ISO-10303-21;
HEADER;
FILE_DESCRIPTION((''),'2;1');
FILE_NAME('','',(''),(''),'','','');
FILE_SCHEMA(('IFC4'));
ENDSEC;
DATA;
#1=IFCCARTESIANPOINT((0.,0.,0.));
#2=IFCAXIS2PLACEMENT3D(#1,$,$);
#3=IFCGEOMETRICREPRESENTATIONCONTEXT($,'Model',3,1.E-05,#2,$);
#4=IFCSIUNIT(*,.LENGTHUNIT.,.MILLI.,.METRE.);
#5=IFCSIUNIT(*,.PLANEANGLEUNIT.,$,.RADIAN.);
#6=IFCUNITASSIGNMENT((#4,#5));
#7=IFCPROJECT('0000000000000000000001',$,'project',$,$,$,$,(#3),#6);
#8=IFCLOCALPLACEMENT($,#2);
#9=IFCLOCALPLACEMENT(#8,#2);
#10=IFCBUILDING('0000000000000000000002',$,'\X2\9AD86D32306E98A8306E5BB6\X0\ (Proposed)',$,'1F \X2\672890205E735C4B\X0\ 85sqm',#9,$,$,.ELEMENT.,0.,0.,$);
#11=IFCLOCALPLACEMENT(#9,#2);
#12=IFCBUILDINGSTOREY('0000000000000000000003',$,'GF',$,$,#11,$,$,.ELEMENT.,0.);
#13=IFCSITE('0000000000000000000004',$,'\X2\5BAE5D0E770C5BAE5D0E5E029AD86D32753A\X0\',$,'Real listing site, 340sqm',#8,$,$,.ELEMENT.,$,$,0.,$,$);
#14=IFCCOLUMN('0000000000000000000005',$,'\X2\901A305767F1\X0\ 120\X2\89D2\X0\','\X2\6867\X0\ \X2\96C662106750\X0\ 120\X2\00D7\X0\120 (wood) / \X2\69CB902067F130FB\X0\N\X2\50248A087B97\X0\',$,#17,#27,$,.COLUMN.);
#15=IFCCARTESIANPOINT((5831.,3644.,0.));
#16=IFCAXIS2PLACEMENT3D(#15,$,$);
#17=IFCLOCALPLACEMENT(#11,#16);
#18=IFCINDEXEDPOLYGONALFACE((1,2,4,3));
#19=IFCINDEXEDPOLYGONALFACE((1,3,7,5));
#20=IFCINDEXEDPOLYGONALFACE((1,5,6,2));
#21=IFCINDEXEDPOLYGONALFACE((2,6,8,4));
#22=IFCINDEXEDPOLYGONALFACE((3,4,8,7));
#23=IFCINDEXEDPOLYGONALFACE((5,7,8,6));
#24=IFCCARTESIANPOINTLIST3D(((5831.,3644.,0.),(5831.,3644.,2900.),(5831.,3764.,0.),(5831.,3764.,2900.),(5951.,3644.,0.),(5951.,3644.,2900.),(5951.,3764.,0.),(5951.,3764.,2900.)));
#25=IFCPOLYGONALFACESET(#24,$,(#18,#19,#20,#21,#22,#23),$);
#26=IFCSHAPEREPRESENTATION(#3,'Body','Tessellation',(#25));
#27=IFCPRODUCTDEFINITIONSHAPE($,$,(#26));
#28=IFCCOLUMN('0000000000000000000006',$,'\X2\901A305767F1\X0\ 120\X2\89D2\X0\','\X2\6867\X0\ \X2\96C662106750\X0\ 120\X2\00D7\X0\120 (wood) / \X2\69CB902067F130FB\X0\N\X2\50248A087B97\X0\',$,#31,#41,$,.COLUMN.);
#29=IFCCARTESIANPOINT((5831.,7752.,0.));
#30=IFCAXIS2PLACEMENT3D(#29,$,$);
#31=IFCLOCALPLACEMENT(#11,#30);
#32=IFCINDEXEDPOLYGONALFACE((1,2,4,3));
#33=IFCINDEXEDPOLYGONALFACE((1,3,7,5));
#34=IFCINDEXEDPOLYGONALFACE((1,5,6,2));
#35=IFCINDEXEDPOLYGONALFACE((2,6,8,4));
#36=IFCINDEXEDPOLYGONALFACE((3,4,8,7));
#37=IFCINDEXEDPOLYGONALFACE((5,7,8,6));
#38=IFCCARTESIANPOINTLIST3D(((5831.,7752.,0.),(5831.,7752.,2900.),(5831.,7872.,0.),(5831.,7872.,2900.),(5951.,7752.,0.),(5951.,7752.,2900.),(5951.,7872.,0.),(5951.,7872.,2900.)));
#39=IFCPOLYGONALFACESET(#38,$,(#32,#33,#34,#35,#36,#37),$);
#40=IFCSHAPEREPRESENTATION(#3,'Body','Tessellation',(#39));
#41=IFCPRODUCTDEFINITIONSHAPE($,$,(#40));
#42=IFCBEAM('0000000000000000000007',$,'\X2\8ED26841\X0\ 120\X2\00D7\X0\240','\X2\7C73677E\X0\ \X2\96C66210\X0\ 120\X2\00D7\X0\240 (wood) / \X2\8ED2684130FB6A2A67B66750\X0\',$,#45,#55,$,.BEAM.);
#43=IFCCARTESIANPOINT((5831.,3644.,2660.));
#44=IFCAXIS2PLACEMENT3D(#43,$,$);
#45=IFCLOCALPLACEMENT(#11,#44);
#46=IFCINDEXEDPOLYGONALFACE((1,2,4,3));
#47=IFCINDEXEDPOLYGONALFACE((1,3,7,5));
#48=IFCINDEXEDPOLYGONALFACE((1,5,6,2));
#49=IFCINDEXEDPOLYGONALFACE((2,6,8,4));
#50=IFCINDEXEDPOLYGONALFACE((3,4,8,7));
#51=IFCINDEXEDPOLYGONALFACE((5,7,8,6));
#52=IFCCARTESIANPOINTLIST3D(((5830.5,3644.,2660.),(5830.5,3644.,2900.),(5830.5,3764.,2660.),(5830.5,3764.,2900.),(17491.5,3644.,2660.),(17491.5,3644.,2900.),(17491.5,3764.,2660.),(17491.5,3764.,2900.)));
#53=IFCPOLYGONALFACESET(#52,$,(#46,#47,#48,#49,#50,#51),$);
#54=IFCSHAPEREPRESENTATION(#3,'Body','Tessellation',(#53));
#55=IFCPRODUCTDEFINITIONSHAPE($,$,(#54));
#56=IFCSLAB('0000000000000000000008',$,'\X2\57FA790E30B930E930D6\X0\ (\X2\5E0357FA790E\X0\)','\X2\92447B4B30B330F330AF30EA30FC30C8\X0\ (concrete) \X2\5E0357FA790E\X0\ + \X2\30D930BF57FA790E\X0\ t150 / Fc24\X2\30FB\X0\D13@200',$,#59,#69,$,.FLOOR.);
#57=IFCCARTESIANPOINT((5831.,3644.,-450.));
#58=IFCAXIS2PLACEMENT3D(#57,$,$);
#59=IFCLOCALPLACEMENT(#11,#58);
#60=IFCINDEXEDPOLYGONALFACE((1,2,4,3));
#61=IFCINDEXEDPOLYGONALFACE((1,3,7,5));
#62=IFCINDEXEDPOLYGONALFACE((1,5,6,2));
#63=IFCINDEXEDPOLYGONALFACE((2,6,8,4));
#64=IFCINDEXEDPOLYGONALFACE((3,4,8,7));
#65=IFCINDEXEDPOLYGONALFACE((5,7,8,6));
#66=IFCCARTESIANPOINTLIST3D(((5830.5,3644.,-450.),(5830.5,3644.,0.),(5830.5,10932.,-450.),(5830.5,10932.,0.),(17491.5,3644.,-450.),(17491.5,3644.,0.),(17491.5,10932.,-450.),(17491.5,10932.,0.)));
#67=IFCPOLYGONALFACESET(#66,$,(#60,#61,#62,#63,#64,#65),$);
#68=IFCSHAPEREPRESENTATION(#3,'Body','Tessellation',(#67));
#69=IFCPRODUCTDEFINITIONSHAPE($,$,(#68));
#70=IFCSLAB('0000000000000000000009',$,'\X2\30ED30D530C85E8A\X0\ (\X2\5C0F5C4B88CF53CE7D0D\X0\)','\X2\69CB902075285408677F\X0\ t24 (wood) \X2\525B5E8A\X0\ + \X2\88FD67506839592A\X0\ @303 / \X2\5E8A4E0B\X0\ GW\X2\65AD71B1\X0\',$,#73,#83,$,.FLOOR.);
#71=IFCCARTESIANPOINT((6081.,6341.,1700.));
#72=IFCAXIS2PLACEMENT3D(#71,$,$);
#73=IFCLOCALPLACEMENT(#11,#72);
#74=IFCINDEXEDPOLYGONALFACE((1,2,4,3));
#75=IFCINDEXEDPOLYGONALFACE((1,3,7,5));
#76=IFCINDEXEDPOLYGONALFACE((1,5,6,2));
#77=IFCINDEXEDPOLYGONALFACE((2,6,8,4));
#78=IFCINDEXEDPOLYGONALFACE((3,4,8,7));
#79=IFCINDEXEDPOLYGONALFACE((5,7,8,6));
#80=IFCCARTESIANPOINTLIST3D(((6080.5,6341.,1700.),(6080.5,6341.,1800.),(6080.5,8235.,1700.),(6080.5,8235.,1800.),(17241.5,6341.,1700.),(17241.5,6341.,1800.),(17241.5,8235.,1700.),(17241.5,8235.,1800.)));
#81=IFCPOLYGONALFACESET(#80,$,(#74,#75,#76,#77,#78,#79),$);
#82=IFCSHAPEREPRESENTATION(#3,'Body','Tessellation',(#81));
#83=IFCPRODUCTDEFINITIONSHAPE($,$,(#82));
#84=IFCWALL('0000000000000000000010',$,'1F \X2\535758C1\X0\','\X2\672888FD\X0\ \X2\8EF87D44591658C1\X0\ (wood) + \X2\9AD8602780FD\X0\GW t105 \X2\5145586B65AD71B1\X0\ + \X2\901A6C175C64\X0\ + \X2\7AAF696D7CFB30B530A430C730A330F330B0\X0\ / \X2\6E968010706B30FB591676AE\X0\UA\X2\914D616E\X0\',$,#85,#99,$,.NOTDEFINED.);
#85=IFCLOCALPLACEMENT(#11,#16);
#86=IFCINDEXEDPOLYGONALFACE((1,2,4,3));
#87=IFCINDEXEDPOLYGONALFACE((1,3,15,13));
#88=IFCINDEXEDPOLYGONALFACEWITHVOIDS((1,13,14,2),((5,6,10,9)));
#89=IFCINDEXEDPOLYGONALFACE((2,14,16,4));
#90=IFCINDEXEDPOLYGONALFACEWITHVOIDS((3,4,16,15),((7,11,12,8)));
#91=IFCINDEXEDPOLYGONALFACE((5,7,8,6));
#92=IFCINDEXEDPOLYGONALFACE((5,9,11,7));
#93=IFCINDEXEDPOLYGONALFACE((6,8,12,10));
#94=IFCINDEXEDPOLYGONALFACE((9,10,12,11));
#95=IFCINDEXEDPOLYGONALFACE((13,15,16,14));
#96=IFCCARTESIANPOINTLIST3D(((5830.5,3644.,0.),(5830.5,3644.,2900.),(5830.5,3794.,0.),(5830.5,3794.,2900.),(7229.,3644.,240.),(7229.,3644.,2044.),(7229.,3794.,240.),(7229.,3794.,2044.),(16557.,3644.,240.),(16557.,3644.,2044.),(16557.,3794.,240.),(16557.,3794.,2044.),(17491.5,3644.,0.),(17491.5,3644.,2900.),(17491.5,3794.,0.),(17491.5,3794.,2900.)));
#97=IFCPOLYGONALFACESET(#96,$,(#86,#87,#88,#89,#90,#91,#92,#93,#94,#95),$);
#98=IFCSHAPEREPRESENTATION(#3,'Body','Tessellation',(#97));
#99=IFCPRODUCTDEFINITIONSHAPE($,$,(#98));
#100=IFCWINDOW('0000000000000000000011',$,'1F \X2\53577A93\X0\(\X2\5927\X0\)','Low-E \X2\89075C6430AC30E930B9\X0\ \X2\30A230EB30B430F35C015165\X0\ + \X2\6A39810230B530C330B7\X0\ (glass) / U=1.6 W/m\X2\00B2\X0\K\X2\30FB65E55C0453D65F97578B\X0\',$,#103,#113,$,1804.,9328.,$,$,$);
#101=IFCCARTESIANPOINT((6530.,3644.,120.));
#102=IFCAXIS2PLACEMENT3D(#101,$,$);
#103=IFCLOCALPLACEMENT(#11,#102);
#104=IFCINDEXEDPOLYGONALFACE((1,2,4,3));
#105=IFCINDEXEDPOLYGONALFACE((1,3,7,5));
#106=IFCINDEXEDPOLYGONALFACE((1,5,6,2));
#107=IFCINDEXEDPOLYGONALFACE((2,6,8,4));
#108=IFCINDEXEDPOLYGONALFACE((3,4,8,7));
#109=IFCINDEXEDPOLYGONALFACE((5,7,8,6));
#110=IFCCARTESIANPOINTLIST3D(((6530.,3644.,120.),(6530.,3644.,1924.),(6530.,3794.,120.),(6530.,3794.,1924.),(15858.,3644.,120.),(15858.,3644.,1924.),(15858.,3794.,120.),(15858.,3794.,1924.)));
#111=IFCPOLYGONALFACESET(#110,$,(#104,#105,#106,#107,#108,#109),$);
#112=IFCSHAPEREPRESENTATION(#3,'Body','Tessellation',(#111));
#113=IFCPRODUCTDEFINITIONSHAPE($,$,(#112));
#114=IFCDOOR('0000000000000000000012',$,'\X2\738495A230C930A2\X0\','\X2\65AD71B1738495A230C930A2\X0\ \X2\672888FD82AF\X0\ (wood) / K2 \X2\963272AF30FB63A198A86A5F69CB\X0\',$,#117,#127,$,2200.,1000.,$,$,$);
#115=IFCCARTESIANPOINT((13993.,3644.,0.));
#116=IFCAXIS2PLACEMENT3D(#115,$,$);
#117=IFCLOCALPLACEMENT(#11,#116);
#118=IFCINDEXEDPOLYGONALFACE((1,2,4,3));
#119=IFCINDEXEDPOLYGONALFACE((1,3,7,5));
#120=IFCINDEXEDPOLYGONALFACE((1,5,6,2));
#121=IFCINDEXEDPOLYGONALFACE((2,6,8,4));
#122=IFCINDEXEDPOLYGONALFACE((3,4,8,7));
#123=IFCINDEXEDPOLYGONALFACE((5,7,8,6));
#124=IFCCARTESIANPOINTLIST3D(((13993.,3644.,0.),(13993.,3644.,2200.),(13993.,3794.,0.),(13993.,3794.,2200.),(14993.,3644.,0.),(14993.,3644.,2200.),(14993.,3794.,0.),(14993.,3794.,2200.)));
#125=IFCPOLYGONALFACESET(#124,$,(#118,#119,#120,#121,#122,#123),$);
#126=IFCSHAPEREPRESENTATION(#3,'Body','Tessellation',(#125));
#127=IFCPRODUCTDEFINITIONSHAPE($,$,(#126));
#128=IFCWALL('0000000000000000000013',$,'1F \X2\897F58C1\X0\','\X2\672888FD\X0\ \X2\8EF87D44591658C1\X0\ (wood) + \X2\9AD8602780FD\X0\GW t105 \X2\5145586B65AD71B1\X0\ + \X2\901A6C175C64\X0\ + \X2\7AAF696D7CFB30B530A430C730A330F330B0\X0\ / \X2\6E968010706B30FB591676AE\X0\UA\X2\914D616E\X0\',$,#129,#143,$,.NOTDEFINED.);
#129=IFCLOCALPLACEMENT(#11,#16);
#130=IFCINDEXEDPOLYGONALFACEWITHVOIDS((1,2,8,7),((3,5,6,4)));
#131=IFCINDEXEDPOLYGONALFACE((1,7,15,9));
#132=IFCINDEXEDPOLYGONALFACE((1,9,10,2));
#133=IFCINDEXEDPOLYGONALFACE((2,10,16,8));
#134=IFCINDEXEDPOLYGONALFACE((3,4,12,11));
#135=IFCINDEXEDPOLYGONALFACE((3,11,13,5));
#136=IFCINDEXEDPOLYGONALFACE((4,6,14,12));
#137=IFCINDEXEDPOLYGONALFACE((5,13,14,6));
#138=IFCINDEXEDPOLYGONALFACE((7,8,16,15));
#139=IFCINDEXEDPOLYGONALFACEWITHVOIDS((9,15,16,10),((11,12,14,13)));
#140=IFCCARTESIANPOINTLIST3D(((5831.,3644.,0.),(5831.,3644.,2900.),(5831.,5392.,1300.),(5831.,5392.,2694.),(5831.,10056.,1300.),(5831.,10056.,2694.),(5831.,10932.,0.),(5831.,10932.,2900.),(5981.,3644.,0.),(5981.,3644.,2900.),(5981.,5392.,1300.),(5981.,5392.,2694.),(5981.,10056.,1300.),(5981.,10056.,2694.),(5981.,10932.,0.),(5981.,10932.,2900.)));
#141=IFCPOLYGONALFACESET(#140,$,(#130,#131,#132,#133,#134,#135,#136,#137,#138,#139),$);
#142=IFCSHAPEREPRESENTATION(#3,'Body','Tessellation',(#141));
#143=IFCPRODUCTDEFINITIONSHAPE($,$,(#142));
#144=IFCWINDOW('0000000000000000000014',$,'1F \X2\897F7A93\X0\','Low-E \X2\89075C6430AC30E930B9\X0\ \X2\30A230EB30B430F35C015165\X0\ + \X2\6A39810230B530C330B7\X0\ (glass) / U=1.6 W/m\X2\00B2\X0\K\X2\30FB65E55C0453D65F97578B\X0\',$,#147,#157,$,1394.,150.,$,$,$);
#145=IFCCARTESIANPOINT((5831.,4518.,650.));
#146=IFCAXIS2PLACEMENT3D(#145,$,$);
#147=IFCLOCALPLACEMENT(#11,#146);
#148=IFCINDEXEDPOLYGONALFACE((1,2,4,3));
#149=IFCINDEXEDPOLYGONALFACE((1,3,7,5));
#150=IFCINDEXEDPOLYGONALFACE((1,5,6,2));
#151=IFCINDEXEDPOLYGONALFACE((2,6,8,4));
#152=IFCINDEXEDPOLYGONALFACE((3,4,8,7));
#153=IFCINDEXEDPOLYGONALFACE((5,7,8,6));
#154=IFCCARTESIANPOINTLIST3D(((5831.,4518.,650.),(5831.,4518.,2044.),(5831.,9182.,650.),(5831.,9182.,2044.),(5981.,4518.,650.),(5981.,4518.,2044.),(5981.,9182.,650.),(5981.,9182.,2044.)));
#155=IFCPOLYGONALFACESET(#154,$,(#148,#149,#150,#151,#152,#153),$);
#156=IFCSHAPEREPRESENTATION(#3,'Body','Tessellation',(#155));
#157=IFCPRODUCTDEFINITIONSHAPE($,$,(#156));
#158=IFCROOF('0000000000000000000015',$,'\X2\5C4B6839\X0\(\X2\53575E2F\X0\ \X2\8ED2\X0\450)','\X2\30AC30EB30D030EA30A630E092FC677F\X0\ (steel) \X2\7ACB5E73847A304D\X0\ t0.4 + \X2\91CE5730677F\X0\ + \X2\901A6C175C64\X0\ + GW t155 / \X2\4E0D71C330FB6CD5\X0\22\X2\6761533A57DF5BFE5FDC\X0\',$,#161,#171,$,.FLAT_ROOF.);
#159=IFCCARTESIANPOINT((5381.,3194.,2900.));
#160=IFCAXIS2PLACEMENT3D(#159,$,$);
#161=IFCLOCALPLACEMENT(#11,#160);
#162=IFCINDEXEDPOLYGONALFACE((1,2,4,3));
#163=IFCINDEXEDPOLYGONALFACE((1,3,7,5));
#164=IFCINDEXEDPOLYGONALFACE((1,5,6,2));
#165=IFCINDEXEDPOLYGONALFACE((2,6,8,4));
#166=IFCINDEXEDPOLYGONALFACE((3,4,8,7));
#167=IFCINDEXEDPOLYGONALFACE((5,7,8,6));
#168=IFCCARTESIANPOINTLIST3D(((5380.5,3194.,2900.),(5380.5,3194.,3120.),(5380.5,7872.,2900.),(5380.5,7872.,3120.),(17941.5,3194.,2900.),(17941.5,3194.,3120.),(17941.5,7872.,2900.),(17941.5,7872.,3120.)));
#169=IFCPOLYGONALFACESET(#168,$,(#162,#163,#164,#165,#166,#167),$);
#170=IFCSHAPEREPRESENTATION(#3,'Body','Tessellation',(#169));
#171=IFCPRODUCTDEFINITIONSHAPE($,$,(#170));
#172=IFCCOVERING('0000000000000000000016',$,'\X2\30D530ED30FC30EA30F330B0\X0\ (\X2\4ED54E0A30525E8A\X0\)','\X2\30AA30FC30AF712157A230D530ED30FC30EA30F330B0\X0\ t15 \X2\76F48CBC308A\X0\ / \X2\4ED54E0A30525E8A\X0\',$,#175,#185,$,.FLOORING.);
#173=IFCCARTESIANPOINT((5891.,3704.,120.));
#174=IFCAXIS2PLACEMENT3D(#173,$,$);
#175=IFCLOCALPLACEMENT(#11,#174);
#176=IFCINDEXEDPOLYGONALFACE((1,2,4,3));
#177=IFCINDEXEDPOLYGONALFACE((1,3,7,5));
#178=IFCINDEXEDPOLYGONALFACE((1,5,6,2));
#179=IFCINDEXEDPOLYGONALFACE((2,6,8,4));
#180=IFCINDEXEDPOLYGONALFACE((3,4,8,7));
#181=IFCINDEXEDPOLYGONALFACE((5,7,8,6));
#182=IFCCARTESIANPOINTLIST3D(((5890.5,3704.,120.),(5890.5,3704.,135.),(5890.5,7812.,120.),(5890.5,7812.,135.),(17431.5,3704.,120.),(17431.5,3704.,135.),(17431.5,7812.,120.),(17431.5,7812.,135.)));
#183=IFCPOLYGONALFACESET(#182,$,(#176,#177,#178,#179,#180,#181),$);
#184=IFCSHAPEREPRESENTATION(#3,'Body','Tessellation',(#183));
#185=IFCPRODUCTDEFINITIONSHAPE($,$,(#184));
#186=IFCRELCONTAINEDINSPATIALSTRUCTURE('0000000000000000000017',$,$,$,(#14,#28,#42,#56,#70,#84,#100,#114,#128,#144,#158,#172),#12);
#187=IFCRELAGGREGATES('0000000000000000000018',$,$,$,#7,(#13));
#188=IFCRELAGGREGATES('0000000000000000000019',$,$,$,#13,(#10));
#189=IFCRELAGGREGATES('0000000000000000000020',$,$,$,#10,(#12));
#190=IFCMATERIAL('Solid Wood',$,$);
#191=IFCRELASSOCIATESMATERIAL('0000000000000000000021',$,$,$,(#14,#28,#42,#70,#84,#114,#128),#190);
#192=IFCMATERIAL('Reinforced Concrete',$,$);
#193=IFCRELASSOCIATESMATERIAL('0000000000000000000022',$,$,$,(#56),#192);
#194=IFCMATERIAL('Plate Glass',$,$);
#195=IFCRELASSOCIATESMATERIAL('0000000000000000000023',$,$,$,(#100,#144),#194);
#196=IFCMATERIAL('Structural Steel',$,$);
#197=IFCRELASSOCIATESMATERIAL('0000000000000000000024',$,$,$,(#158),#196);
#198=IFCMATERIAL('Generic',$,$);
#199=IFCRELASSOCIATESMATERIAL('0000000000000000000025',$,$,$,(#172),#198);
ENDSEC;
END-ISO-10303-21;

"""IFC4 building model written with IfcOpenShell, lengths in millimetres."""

from ifc_helpers import new_model, si_unit, frame, frame_2d, origin, place, context, project, spatial, rectangle, extrude, material, element, fill, save


model = new_model("IFC4")

# Units and contexts
model_context = context("Model", 3, precision=1e-05, world=origin())
ifc_project = project(units=[si_unit("LENGTHUNIT", "METRE", prefix="MILLI"), si_unit("PLANEANGLEUNIT", "RADIAN")], contexts=[model_context])

# Site, building, storey
site_placement = place(None, origin())
site = spatial("IfcSite", under=ifc_project, at=site_placement, Name="宮崎県宮崎市高洲町", ObjectType="Real listing site, 340sqm", CompositionType="ELEMENT", RefElevation=0.0)
building_placement = place(site_placement, origin())
building = spatial("IfcBuilding", under=site, at=building_placement, Name="高洲の風の家 (Proposed)", ObjectType="1F 木造平屋 85sqm", CompositionType="ELEMENT", ElevationOfRefHeight=0.0, ElevationOfTerrain=0.0)
storey_placement = place(building_placement, origin())
storey = spatial("IfcBuildingStorey", under=building, at=storey_placement, Name="GF", CompositionType="ELEMENT", Elevation=0.0)

# Columns
ifc_material_1 = material(Name="Solid Wood")
column_1_placement = place(storey_placement, frame((5831.0, 3644.0, 0.0)))
element("IfcColumn", 1, at=column_1_placement, inside=storey, material=ifc_material_1, Name="通し柱 120角", Description="桧 集成材 120×120 (wood) / 構造柱・N値計算", PredefinedType="COLUMN", context=model_context, shape_type="SweptSolid", body=[
    extrude(rectangle(XDim=120.0, YDim=120.0, at=frame_2d((60.0, 60.0))), frame((5831.0, 3644.0, 0.0)), (0.0, 0.0, 1.0), 2900.0),
])
column_2_placement = place(storey_placement, frame((5831.0, 7752.0, 0.0)))
element("IfcColumn", 2, at=column_2_placement, inside=storey, material=ifc_material_1, Name="通し柱 120角", Description="桧 集成材 120×120 (wood) / 構造柱・N値計算", PredefinedType="COLUMN", context=model_context, shape_type="SweptSolid", body=[
    extrude(rectangle(XDim=120.0, YDim=120.0, at=frame_2d((60.0, 60.0))), frame((5831.0, 7752.0, 0.0)), (0.0, 0.0, 1.0), 2900.0),
])

# Beam
beam_1_placement = place(storey_placement, frame((5831.0, 3644.0, 2660.0)))
element("IfcBeam", 3, at=beam_1_placement, inside=storey, material=ifc_material_1, Name="軒桁 120×240", Description="米松 集成 120×240 (wood) / 軒桁・横架材", PredefinedType="BEAM", context=model_context, shape_type="SweptSolid", body=[
    extrude(rectangle(XDim=11661.0, YDim=120.0, at=frame_2d((5830.0, 60.0))), frame((5831.0, 3644.0, 2660.0)), (0.0, 0.0, 1.0), 240.0),
])

# Slabs
ifc_material_2 = material(Name="Reinforced Concrete")
slab_1_placement = place(storey_placement, frame((5831.0, 3644.0, -450.0)))
element("IfcSlab", 4, at=slab_1_placement, inside=storey, material=ifc_material_2, Name="基礎スラブ (布基礎)", Description="鉄筋コンクリート (concrete) 布基礎 + ベタ基礎 t150 / Fc24・D13@200", PredefinedType="FLOOR", context=model_context, shape_type="SweptSolid", body=[
    extrude(rectangle(XDim=11661.0, YDim=7288.0, at=frame_2d((5830.0, 3644.0))), frame((5831.0, 3644.0, -450.0)), (0.0, 0.0, 1.0), 450.0),
])
slab_2_placement = place(storey_placement, frame((6081.0, 6341.0, 1700.0)))
element("IfcSlab", 5, at=slab_2_placement, inside=storey, material=ifc_material_1, Name="ロフト床 (小屋裏収納)", Description="構造用合板 t24 (wood) 剛床 + 製材根太 @303 / 床下 GW断熱", PredefinedType="FLOOR", context=model_context, shape_type="SweptSolid", body=[
    extrude(rectangle(XDim=11161.0, YDim=1894.0, at=frame_2d((5580.0, 947.0))), frame((6081.0, 6341.0, 1700.0)), (0.0, 0.0, 1.0), 100.0),
])

# Wall, openings, window, door
wall_1_placement = place(storey_placement, frame((5831.0, 3644.0, 0.0)))
wall_1 = element("IfcWall", 6, at=wall_1_placement, inside=storey, material=ifc_material_1, Name="1F 南壁", Description="木製 軸組外壁 (wood) + 高性能GW t105 充填断熱 + 通気層 + 窯業系サイディング / 準耐火・外皮UA配慮", PredefinedType="NOTDEFINED", context=model_context, shape_type="SweptSolid", body=[
    extrude(rectangle(XDim=11661.0, YDim=150.0, at=frame_2d((5830.0, 75.0))), frame((5831.0, 3644.0, 0.0)), (0.0, 0.0, 1.0), 2900.0),
])
opening_1_placement = place(storey_placement, frame((6530.0, 3644.0, 120.0)))
opening_1 = element("IfcOpeningElement", 7, at=opening_1_placement, cuts=wall_1, PredefinedType="NOTDEFINED", context=model_context, shape_type="SweptSolid", body=[
    extrude(rectangle(XDim=9328.0, YDim=150.0, at=frame_2d((4664.0, 75.0))), frame((6530.0, 3644.0, 120.0)), (0.0, 0.0, 1.0), 1804.0),
])
opening_2_placement = place(storey_placement, frame((13993.0, 3644.0, 0.0)))
opening_2 = element("IfcOpeningElement", 8, at=opening_2_placement, cuts=wall_1, PredefinedType="NOTDEFINED", context=model_context, shape_type="SweptSolid", body=[
    extrude(rectangle(XDim=1000.0, YDim=150.0, at=frame_2d((500.0, 75.0))), frame((13993.0, 3644.0, 0.0)), (0.0, 0.0, 1.0), 2200.0),
])
ifc_material_3 = material(Name="Plate Glass")
window_1_placement = place(storey_placement, frame((6530.0, 3644.0, 120.0)))
window_1 = element("IfcWindow", 9, at=window_1_placement, inside=storey, material=ifc_material_3, Name="1F 南窓(大)", Description="Low-E 複層ガラス アルゴン封入 + 樹脂サッシ (glass) / U=1.6 W/m²K・日射取得型", OverallHeight=1804.0, OverallWidth=9328.0, context=model_context, shape_type="SweptSolid", body=[
    extrude(rectangle(XDim=9328.0, YDim=150.0, at=frame_2d((4664.0, 75.0))), frame((6530.0, 3644.0, 120.0)), (0.0, 0.0, 1.0), 1804.0),
])
fill(opening_1, window_1)
door_placement = place(storey_placement, frame((13993.0, 3644.0, 0.0)))
door = element("IfcDoor", 10, at=door_placement, inside=storey, material=ifc_material_1, Name="玄関ドア", Description="断熱玄関ドア 木製芯 (wood) / K2 防犯・採風機構", OverallHeight=2200.0, OverallWidth=1000.0, context=model_context, shape_type="SweptSolid", body=[
    extrude(rectangle(XDim=1000.0, YDim=150.0, at=frame_2d((500.0, 75.0))), frame((13993.0, 3644.0, 0.0)), (0.0, 0.0, 1.0), 2200.0),
])
fill(opening_2, door)

# Wall, opening, window
wall_2_placement = place(storey_placement, frame((5831.0, 3644.0, 0.0)))
wall_2 = element("IfcWall", 11, at=wall_2_placement, inside=storey, material=ifc_material_1, Name="1F 西壁", Description="木製 軸組外壁 (wood) + 高性能GW t105 充填断熱 + 通気層 + 窯業系サイディング / 準耐火・外皮UA配慮", PredefinedType="NOTDEFINED", context=model_context, shape_type="SweptSolid", body=[
    extrude(rectangle(XDim=150.0, YDim=7288.0, at=frame_2d((75.0, 3644.0))), frame((5831.0, 3644.0, 0.0)), (0.0, 0.0, 1.0), 2900.0),
])
opening_3_placement = place(storey_placement, frame((5831.0, 4518.0, 650.0)))
opening_3 = element("IfcOpeningElement", 12, at=opening_3_placement, cuts=wall_2, PredefinedType="NOTDEFINED", context=model_context, shape_type="SweptSolid", body=[
    extrude(rectangle(XDim=150.0, YDim=4664.0, at=frame_2d((75.0, 2332.0))), frame((5831.0, 4518.0, 650.0)), (0.0, 0.0, 1.0), 1394.0),
])
window_2_placement = place(storey_placement, frame((5831.0, 4518.0, 650.0)))
window_2 = element("IfcWindow", 13, at=window_2_placement, inside=storey, material=ifc_material_3, Name="1F 西窓", Description="Low-E 複層ガラス アルゴン封入 + 樹脂サッシ (glass) / U=1.6 W/m²K・日射取得型", OverallHeight=1394.0, OverallWidth=150.0, context=model_context, shape_type="SweptSolid", body=[
    extrude(rectangle(XDim=150.0, YDim=4664.0, at=frame_2d((75.0, 2332.0))), frame((5831.0, 4518.0, 650.0)), (0.0, 0.0, 1.0), 1394.0),
])
fill(opening_3, window_2)

# Roof
ifc_material_4 = material(Name="Structural Steel")
roof_placement = place(storey_placement, frame((5381.0, 3194.0, 2900.0)))
element("IfcRoof", 14, at=roof_placement, inside=storey, material=ifc_material_4, Name="屋根(南帯 軒450)", Description="ガルバリウム鋼板 (steel) 立平葺き t0.4 + 野地板 + 通気層 + GW t155 / 不燃・法22条区域対応", PredefinedType="FLAT_ROOF", context=model_context, shape_type="SweptSolid", body=[
    extrude(rectangle(XDim=12561.0, YDim=4678.0, at=frame_2d((6280.0, 2339.0))), frame((5381.0, 3194.0, 2900.0)), (0.0, 0.0, 1.0), 220.0),
])

# Covering
ifc_material_5 = material(Name="Generic")
covering_1_placement = place(storey_placement, frame((5891.0, 3704.0, 120.0)))
element("IfcCovering", 15, at=covering_1_placement, inside=storey, material=ifc_material_5, Name="フローリング (仕上げ床)", Description="オーク無垢フローリング t15 直貼り / 仕上げ床", PredefinedType="FLOORING", context=model_context, shape_type="SweptSolid", body=[
    extrude(rectangle(XDim=11541.0, YDim=4108.0, at=frame_2d((5770.0, 2054.0))), frame((5891.0, 3704.0, 120.0)), (0.0, 0.0, 1.0), 15.0),
])

save(model, "model.ifc")
